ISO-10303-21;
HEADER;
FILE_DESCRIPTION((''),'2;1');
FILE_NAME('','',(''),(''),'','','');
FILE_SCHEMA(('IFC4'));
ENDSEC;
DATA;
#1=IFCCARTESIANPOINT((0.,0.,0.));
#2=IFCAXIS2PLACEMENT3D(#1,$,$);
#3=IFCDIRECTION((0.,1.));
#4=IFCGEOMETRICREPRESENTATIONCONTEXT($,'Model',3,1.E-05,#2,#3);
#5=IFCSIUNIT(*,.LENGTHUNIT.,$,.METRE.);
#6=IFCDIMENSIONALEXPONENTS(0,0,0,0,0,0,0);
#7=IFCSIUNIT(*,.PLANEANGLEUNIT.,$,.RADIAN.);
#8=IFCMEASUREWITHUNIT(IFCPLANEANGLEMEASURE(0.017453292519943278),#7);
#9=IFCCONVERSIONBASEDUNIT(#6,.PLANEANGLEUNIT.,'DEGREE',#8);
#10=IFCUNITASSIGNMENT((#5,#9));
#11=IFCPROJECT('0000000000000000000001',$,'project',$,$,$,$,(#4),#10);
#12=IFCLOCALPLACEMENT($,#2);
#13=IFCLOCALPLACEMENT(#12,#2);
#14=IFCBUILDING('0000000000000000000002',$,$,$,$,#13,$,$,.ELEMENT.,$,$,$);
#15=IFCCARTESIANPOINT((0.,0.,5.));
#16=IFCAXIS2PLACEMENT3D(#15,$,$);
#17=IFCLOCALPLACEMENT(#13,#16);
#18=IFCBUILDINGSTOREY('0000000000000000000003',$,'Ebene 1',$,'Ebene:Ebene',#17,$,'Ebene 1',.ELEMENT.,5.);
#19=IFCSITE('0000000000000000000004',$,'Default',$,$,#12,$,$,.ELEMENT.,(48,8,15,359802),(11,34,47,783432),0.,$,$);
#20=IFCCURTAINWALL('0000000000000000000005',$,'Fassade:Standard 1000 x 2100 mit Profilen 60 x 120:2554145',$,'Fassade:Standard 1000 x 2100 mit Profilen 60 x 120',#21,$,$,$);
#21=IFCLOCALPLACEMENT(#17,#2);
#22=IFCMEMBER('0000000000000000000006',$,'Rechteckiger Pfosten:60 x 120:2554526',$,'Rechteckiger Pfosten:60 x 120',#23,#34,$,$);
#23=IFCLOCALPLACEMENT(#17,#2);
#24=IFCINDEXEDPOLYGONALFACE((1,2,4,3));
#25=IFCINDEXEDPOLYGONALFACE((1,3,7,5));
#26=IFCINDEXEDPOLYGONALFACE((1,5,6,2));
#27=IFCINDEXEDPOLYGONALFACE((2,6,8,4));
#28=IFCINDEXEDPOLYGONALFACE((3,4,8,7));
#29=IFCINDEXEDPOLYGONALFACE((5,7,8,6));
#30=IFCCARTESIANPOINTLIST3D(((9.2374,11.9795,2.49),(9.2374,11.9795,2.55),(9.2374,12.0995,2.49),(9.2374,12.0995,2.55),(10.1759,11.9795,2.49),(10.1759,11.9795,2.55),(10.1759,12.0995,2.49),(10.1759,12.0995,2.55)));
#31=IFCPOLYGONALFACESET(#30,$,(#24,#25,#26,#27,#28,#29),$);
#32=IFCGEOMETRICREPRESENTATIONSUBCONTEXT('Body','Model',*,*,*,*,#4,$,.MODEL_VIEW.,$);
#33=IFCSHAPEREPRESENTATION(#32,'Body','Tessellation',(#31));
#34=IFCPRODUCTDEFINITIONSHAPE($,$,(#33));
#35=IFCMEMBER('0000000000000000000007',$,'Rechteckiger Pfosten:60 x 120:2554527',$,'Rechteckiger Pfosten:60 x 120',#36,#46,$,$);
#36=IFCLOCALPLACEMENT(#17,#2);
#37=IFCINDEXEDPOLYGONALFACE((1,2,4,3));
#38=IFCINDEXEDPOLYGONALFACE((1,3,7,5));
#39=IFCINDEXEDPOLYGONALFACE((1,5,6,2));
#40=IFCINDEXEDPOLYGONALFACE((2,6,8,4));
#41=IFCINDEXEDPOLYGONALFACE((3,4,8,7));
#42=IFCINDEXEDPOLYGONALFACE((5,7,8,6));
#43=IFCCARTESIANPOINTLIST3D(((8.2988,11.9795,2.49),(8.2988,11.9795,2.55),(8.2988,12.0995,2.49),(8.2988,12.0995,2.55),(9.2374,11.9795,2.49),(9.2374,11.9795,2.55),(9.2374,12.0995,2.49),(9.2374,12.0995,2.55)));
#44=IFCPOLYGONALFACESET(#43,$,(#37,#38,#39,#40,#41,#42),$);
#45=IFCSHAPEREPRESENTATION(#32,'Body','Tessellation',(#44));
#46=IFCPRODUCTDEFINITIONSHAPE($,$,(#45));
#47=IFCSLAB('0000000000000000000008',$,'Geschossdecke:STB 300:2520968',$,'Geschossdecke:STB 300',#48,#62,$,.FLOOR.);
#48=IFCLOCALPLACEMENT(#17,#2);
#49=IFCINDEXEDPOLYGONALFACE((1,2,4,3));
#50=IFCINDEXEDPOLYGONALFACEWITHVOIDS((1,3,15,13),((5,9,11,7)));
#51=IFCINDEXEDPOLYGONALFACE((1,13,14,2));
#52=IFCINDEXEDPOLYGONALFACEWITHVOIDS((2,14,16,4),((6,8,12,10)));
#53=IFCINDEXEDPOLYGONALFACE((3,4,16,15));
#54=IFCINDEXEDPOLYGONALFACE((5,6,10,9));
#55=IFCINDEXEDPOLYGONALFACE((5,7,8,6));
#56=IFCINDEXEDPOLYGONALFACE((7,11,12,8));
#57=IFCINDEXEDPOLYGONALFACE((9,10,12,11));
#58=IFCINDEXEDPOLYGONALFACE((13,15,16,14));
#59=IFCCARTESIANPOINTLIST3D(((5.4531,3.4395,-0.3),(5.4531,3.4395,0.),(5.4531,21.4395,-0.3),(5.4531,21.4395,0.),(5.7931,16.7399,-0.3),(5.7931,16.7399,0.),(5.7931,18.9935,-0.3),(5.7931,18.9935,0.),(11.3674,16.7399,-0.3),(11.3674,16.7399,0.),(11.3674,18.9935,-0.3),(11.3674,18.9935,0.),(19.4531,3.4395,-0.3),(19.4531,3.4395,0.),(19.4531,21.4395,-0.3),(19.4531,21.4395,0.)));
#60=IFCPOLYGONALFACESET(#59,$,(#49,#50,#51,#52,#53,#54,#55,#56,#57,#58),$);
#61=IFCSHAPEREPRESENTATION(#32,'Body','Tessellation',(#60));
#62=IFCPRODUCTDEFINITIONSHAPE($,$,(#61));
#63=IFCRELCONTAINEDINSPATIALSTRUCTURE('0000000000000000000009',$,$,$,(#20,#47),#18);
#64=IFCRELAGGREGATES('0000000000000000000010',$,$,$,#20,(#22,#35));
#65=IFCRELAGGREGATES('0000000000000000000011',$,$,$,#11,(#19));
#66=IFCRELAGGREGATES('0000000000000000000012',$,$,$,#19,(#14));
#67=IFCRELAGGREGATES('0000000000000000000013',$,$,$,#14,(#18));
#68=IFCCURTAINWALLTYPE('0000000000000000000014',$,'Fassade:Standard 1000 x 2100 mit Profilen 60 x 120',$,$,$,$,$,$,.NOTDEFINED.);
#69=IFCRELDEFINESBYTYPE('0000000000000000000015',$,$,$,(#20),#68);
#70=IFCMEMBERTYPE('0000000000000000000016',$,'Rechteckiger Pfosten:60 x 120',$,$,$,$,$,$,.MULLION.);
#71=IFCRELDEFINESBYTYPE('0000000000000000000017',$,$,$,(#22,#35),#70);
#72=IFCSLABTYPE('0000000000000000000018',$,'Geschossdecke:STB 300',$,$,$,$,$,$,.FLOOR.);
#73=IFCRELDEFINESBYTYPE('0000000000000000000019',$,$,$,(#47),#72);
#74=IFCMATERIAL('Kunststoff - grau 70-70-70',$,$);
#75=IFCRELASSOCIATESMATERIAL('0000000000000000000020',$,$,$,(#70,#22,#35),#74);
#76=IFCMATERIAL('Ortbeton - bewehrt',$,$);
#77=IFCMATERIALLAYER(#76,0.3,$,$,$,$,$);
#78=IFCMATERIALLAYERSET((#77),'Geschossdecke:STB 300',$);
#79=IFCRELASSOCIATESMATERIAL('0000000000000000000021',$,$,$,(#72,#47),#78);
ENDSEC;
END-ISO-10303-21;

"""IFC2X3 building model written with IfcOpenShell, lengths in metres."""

from ifc_helpers import new_model, entity, si_unit, converted_unit, direction, frame, frame_2d, origin, origin_2d_with_axis, place, context, subcontext, project, spatial, rectangle, extrude, source, transform, mapped, material, layer, layer_set, layer_usage, type_object, type_shapes, element, aggregate, save


model = new_model("IFC2X3")

# Units and contexts
model_context = context("Model", 3, precision=1e-05, world=origin(), true_north=direction((0.0, 1.0)))
body_context = subcontext(model_context, "Body", "Model", "MODEL_VIEW")
ifc_project = project(units=[si_unit("LENGTHUNIT", "METRE"), converted_unit("PLANEANGLEUNIT", "DEGREE", entity("IfcPlaneAngleMeasure", 0.017453292519943278), si_unit("PLANEANGLEUNIT", "RADIAN"), dimensions=[0, 0, 0, 0, 0, 0, 0])], contexts=[model_context])

# Site, building, storey
site_placement = place(None, origin())
site = spatial("IfcSite", under=ifc_project, at=site_placement, Name="Default", CompositionType="ELEMENT", RefLatitude=(48, 8, 15, 359802), RefLongitude=(11, 34, 47, 783432), RefElevation=0.0)
building_placement = place(site_placement, origin())
building = spatial("IfcBuilding", under=site, at=building_placement, CompositionType="ELEMENT")
storey_placement = place(building_placement, frame((0.0, 0.0, 5.0)))
storey = spatial("IfcBuildingStorey", under=building, at=storey_placement, Name="Ebene 1", ObjectType="Ebene:Ebene", LongName="Ebene 1", CompositionType="ELEMENT", Elevation=5.0)

# Curtain wall, members
curtain_wall_type = type_object("IfcCurtainWallType", Name="Fassade:Standard 1000 x 2100 mit Profilen 60 x 120", PredefinedType="NOTDEFINED")
curtain_wall_placement = place(storey_placement, frame((0.0, 0.0, -5.0)))
curtain_wall = element("IfcCurtainWall", 1, at=curtain_wall_placement, inside=storey, type_object=curtain_wall_type, Name="Fassade:Standard 1000 x 2100 mit Profilen 60 x 120:2554145", ObjectType="Fassade:Standard 1000 x 2100 mit Profilen 60 x 120")
ifc_material_1 = material(Name="Kunststoff - grau 70-70-70")
member_type_1 = type_object("IfcMemberType", Name="Rechteckiger Pfosten:60 x 120", PredefinedType="MULLION", material=ifc_material_1)
shared_shape_1 = source(origin(), body_context, "Body", "SweptSolid", [
    extrude(rectangle(XDim=0.06, YDim=0.12, at=origin_2d_with_axis()), frame((-0.03, 0.0, -0.9386), z_axis=(0.0, 0.0, 1.0), x_axis=(-1.0, 0.0, 0.0)), (0.0, 0.0, 1.0), 0.9386),
])
type_shapes(member_type_1, [shared_shape_1])
member_1_placement = place(curtain_wall_placement, frame((9.2374, 12.0395, 7.55), z_axis=(-1.0, 0.0, 0.0), x_axis=(0.0, 0.0, 1.0)))
member_1 = element("IfcMember", 2, at=member_1_placement, type_object=member_type_1, material=ifc_material_1, Name="Rechteckiger Pfosten:60 x 120:2554526", ObjectType="Rechteckiger Pfosten:60 x 120", context=body_context, shape_type="MappedRepresentation", body=[
    mapped(shared_shape_1, transform((0.0, 0.0, 0.0), scale=1.0)),
])
member_2_placement = place(curtain_wall_placement, frame((8.2988, 12.0395, 7.55), z_axis=(-1.0, 0.0, 0.0), x_axis=(0.0, 0.0, 1.0)))
member_2 = element("IfcMember", 3, at=member_2_placement, type_object=member_type_1, material=ifc_material_1, Name="Rechteckiger Pfosten:60 x 120:2554527", ObjectType="Rechteckiger Pfosten:60 x 120", context=body_context, shape_type="MappedRepresentation", body=[
    mapped(shared_shape_1, transform((0.0, 0.0, 0.0), scale=1.0)),
])

# Slab, opening
ifc_material_2 = material(Name="Ortbeton - bewehrt")
ifc_layer = layer(ifc_material_2, 0.3)
ifc_layer_set = layer_set([ifc_layer], Name="Geschossdecke:STB 300")
ifc_layer_usage = layer_usage(ifc_layer_set, "AXIS3", "POSITIVE", 0.0)
slab_type = type_object("IfcSlabType", Name="Geschossdecke:STB 300", PredefinedType="FLOOR", material=ifc_layer_set)
slab_placement = place(storey_placement, frame((5.4531, 3.4395, -0.3)))
slab = element("IfcSlab", 4, at=slab_placement, inside=storey, type_object=slab_type, material=ifc_layer_usage, Name="Geschossdecke:STB 300:2520968", ObjectType="Geschossdecke:STB 300", PredefinedType="FLOOR", context=body_context, shape_type="SweptSolid", body=[
    extrude(rectangle(XDim=18.0, YDim=14.0, at=frame_2d((0.0, 0.0), x_axis=(0.0, -1.0))), frame((7.0, 9.0, 0.3), z_axis=(0.0, 0.0, -1.0), x_axis=(-1.0, 0.0, 0.0)), (0.0, 0.0, 1.0), 0.3),
])
opening_placement = place(slab_placement, origin())
element("IfcOpeningElement", 5, at=opening_placement, cuts=slab, ObjectType="Opening", context=body_context, shape_type="SweptSolid", body=[
    extrude(rectangle(XDim=2.2536, YDim=5.5743, at=frame_2d((0.0, 0.0), x_axis=(1.0, 0.0))), frame((3.1272, 14.4272, 0.3), z_axis=(0.0, 0.0, -1.0), x_axis=(0.0, 1.0, 0.0)), (0.0, 0.0, 1.0), 0.3),
])

aggregate(curtain_wall, [member_1, member_2])

save(model, "model.ifc")
